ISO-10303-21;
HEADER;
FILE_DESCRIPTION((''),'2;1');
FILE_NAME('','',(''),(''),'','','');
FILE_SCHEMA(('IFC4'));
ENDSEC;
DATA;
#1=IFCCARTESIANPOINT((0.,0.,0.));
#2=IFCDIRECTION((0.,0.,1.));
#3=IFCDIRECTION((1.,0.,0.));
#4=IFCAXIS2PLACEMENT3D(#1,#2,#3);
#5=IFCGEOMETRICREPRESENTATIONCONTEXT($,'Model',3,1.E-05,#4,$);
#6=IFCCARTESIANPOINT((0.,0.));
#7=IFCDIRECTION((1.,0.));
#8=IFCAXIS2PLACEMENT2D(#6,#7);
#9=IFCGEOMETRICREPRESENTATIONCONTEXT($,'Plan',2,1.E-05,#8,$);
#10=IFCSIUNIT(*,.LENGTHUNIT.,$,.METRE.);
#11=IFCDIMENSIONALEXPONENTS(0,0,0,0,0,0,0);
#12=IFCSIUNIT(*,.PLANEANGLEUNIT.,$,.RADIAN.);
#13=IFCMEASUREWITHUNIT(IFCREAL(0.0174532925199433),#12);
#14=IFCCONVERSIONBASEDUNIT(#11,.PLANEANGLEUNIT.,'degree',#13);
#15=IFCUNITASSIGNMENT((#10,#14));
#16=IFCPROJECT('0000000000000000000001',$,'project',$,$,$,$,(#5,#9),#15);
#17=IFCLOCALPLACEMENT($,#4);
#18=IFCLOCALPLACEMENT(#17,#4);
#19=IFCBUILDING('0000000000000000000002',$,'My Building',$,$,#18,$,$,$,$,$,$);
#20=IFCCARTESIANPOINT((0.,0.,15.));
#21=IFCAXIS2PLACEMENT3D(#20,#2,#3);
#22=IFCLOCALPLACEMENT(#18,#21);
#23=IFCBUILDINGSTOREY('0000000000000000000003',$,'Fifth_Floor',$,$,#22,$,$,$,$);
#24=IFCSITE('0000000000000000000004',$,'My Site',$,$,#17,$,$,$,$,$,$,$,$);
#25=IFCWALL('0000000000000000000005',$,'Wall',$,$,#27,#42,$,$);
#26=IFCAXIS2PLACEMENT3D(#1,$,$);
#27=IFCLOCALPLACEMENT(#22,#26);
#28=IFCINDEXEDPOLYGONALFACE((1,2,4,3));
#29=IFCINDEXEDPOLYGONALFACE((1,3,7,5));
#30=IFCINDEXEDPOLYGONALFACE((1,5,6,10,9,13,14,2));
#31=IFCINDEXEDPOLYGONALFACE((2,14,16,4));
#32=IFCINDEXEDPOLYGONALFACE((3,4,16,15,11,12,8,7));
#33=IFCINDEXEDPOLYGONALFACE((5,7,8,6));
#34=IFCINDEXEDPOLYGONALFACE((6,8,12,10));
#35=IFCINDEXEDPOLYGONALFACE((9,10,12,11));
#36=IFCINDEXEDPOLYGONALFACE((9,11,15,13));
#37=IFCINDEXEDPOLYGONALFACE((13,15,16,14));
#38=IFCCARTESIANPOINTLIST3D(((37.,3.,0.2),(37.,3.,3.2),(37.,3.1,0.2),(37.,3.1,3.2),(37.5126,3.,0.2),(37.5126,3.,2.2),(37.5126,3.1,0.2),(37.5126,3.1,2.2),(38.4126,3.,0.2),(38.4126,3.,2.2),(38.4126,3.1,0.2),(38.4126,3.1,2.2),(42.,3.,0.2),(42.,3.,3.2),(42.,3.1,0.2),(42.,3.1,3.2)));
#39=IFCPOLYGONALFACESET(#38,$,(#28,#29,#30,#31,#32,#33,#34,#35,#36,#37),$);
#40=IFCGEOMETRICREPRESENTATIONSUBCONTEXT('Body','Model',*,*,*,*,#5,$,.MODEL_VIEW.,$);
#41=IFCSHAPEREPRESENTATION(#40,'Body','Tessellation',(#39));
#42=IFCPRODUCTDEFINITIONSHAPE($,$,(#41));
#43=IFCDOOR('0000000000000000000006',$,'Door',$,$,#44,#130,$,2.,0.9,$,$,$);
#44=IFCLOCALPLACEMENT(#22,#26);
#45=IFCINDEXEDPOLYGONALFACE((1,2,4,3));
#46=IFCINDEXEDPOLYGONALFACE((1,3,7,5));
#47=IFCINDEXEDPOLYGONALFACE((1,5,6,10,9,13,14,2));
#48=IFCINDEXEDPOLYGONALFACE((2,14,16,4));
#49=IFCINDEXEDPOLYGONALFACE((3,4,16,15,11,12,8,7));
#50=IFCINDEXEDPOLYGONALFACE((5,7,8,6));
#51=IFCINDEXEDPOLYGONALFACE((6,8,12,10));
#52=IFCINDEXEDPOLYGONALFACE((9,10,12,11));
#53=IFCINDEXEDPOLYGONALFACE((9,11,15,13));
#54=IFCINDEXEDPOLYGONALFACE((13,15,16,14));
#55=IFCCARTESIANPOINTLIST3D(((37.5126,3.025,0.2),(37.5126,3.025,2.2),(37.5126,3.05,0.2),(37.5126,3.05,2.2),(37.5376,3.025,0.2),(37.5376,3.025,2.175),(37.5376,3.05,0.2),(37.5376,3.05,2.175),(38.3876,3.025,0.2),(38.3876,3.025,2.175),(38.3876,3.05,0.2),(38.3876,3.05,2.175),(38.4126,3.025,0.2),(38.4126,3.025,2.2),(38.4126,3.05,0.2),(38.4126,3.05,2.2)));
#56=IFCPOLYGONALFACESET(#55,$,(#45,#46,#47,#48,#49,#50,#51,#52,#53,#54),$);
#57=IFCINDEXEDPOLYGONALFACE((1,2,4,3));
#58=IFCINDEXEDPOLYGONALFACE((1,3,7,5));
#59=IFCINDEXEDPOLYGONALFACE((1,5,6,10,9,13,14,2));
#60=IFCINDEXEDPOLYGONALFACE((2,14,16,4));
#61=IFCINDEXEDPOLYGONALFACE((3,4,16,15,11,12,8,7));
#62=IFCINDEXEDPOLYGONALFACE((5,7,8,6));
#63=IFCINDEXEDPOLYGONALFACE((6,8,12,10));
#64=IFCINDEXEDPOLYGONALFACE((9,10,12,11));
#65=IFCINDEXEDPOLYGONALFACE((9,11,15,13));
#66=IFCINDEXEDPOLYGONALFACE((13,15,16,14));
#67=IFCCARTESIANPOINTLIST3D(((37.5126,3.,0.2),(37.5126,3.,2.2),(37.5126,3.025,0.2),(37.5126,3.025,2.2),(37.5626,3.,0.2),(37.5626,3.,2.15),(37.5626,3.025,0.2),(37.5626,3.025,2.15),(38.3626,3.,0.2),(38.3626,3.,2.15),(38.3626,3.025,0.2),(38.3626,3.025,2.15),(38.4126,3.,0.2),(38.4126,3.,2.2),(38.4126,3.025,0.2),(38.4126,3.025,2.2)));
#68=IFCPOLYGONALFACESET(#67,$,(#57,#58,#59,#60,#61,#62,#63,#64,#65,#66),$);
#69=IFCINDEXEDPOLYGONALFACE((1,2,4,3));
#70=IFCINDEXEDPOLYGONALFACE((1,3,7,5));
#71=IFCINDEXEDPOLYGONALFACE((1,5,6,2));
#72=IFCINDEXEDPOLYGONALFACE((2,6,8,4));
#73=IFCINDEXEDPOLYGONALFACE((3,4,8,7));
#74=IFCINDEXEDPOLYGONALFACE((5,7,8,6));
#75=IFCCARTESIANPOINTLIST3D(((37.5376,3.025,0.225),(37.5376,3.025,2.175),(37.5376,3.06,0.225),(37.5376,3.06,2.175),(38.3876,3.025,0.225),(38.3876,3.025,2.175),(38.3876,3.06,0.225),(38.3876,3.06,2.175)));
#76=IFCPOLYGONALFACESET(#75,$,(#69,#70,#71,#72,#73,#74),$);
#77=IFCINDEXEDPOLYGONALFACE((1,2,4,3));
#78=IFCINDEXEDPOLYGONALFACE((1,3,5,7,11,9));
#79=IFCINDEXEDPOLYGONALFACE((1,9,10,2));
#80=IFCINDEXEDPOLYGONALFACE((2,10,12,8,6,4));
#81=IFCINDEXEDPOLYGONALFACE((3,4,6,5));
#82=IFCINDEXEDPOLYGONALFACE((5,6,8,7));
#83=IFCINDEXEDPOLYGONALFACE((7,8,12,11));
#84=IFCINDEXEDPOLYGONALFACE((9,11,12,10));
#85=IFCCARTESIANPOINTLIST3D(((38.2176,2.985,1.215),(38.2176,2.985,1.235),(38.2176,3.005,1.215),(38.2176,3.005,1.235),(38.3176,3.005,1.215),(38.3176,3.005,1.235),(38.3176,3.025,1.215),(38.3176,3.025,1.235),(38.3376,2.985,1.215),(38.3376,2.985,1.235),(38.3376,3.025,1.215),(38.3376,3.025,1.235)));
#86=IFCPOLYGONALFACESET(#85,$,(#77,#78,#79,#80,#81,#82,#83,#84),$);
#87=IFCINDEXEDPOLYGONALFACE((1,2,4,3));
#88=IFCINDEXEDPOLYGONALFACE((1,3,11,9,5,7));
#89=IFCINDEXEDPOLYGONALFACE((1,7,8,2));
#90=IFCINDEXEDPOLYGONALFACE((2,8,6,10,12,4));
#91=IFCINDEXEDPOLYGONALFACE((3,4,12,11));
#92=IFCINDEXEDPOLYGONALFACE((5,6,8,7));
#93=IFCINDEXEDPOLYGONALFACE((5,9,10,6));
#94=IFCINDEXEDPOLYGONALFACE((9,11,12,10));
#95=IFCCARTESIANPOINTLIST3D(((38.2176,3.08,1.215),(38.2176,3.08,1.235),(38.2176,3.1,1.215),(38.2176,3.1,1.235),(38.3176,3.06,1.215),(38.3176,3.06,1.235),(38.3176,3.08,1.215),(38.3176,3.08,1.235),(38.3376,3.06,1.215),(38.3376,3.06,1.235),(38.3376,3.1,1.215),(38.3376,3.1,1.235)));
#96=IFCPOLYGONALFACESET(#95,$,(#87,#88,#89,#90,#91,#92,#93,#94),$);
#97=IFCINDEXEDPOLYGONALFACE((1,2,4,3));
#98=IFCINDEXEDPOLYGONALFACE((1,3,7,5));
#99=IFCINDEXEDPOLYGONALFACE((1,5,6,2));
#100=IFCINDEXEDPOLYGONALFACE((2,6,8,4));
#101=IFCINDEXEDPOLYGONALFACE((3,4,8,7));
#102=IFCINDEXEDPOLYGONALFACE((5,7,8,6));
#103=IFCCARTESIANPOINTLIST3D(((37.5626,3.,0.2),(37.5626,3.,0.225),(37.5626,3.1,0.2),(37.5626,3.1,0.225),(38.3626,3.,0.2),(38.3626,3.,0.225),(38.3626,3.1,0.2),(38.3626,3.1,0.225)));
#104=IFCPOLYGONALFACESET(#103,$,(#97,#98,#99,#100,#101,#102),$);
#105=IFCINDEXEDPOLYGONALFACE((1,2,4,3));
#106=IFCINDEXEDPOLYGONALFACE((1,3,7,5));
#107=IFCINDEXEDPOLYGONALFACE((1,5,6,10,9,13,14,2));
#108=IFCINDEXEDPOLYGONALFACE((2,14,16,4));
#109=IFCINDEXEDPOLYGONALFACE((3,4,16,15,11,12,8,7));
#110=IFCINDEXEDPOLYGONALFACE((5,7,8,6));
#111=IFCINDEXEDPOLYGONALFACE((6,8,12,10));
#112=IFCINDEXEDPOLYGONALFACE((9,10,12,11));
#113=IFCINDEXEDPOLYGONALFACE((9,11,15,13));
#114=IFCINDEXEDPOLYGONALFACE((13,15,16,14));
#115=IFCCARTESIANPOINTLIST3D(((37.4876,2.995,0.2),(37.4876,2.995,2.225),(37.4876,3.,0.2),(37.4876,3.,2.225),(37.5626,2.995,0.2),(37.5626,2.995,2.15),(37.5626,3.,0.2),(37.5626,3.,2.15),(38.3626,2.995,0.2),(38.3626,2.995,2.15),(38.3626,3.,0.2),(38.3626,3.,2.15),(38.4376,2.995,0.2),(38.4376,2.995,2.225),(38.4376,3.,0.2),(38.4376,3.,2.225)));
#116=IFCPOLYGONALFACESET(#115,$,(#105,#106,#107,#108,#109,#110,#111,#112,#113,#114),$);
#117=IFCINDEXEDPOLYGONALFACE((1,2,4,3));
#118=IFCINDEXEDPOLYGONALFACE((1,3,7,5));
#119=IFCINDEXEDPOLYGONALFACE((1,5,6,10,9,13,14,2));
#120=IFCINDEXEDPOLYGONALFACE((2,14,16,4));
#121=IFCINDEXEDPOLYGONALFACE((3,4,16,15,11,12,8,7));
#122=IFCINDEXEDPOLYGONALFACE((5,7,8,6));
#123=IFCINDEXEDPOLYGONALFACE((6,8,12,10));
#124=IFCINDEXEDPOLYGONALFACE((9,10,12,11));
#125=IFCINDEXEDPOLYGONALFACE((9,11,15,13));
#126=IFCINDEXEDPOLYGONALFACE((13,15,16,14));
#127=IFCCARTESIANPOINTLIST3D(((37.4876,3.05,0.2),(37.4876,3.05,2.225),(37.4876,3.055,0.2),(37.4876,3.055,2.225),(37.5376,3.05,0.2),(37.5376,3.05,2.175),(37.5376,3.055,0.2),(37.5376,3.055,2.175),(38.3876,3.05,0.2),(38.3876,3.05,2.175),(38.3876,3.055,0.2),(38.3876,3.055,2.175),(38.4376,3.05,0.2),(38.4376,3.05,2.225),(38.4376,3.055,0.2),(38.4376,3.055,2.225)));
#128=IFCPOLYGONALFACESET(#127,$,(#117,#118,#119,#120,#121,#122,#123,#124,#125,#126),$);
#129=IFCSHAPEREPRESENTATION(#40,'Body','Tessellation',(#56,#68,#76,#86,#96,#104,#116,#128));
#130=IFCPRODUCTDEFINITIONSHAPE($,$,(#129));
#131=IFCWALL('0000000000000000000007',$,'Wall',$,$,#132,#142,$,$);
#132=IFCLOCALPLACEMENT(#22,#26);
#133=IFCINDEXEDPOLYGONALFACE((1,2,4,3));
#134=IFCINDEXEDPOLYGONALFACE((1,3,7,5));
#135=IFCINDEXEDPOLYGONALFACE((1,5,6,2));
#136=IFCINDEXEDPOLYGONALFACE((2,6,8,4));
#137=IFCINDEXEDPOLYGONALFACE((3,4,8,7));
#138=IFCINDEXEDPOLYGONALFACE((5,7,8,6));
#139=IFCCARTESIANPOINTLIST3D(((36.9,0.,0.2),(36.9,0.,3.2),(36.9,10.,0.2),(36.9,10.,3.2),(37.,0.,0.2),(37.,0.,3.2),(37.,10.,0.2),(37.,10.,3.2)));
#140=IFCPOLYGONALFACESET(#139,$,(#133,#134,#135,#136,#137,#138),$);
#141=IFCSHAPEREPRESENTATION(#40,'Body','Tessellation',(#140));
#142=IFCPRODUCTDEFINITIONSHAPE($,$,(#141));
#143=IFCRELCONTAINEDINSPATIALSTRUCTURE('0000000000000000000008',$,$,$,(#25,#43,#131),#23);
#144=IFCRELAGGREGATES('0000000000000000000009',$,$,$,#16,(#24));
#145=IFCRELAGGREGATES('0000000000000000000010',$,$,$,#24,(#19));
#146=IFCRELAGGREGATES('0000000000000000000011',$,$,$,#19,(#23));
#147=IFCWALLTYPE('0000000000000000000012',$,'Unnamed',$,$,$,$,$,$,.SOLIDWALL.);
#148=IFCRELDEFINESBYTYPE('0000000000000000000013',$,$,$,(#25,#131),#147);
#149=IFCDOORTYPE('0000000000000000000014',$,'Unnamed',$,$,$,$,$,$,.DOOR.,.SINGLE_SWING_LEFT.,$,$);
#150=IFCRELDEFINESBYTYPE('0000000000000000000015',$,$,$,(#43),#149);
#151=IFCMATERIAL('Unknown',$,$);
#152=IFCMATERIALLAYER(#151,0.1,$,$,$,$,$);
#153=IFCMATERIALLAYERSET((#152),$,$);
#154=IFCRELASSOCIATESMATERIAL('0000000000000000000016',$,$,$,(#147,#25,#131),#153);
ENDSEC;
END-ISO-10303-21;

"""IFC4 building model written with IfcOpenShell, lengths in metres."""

from ifc_helpers import new_model, entity, si_unit, converted_unit, frame, origin_with_axes, origin_2d_with_axis, place, context, subcontext, project, spatial, line, indexed_curve, outline, extrude, shape, source, transform, mapped, material, layer, layer_set, layer_usage, type_object, type_shapes, element, fill, save


model = new_model("IFC4")

# Units and contexts
model_context = context("Model", 3, precision=1e-05, world=origin_with_axes())
plan_context = context("Plan", 2, precision=1e-05, world=origin_2d_with_axis())
body_context_1 = subcontext(model_context, "Body", "Model", "MODEL_VIEW")
body_context_2 = subcontext(plan_context, "Body", "Plan", "PLAN_VIEW")
ifc_project = project(units=[si_unit("LENGTHUNIT", "METRE"), converted_unit("PLANEANGLEUNIT", "degree", entity("IfcReal", 0.0174532925199433), si_unit("PLANEANGLEUNIT", "RADIAN"), dimensions=[0, 0, 0, 0, 0, 0, 0])], contexts=[model_context, plan_context])

# Site, building, storey
site_placement = place(None, origin_with_axes())
site = spatial("IfcSite", under=ifc_project, at=site_placement, Name="My Site")
building_placement = place(site_placement, origin_with_axes())
building = spatial("IfcBuilding", under=site, at=building_placement, Name="My Building")
storey_placement = place(building_placement, frame((0.0, 0.0, 15.0), z_axis=(0.0, 0.0, 1.0), x_axis=(1.0, 0.0, 0.0)))
storey = spatial("IfcBuildingStorey", under=building, at=storey_placement, Name="Fifth_Floor")

# Wall, opening, door
ifc_material = material(Name="Unknown")
ifc_layer = layer(ifc_material, 0.1)
ifc_layer_set = layer_set([ifc_layer])
ifc_layer_usage_1 = layer_usage(ifc_layer_set, "AXIS2", "POSITIVE", 0.0)
wall_type = type_object("IfcWallType", Name="Unnamed", PredefinedType="SOLIDWALL", material=ifc_layer_set)
wall_1_placement = place(storey_placement, frame((37.0, 3.0, 0.2), z_axis=(0.0, 0.0, 1.0), x_axis=(1.0, 0.0, 0.0)))
wall_1 = element("IfcWall", 1, at=wall_1_placement, inside=storey, type_object=wall_type, material=ifc_layer_usage_1, Name="Wall", context=body_context_1, shape_type="SweptSolid", body=[
    extrude(outline(indexed_curve([(0.0, 0.0), (0.0, 0.1), (5.0, 0.1), (5.0, 0.0)], segments=[line(1, 2, 3, 4, 1)])), origin_with_axes(), (0.0, 0.0, 1.0), 3.0),
])
shared_shape_1 = source(origin_with_axes(), body_context_1, "Body", "SweptSolid", [
    extrude(outline(indexed_curve([(0.0, 0.0), (0.9, 0.0), (0.9, 2.0), (0.0, 2.0)], segments=[line(1, 2, 3, 4, 1)])), frame((0.0, -0.6, 0.0), z_axis=(0.0, -1.0, 0.0), x_axis=(1.0, 0.0, 0.0)), (0.0, 0.0, -1.0), 1.2),
])
opening_1_placement = place(wall_1_placement, frame((0.5126, 0.0, 0.0), z_axis=(0.0, 0.0, 1.0), x_axis=(1.0, 0.0, 0.0)))
opening_1 = element("IfcOpeningElement", 2, at=opening_1_placement, cuts=wall_1, PredefinedType="OPENING", context=body_context_1, shape_type="MappedRepresentation", body=[
    mapped(shared_shape_1, transform((0.0, 0.0, 0.0), x_axis=(1.0, 0.0, 0.0), y_axis=(0.0, 1.0, 0.0), z_axis=(0.0, 0.0, 1.0), scale=1.0)),
])
door_type = type_object("IfcDoorType", Name="Unnamed", OperationType="SINGLE_SWING_LEFT", PredefinedType="DOOR")
shared_shape_2 = source(origin_with_axes(), body_context_1, "Body", "SweptSolid", [
    extrude(outline(indexed_curve([(0.0, 0.0), (0.0, 2.0), (0.9, 2.0), (0.9, 0.0), (0.875, 0.0), (0.875, 1.975), (0.025, 1.975), (0.025, 0.0)], segments=[line(1, 2, 3, 4, 5, 6, 7, 8, 1)])), frame((0.0, 0.025, 0.0), z_axis=(0.0, -1.0, 0.0), x_axis=(1.0, 0.0, 0.0)), (0.0, 0.0, -1.0), 0.025),
    extrude(outline(indexed_curve([(0.0, 0.0), (0.0, 2.0), (0.9, 2.0), (0.9, 0.0), (0.85, 0.0), (0.85, 1.95), (0.05, 1.95), (0.05, 0.0)], segments=[line(1, 2, 3, 4, 5, 6, 7, 8, 1)])), frame((0.0, 0.0, 0.0), z_axis=(0.0, -1.0, 0.0), x_axis=(1.0, 0.0, 0.0)), (0.0, 0.0, -1.0), 0.025),
    extrude(outline(indexed_curve([(0.0, 0.0), (0.85, 0.0), (0.85, 0.035), (0.0, 0.035)], segments=[line(1, 2, 3, 4, 1)])), frame((0.025, 0.025, 0.025), z_axis=(0.0, 0.0, 1.0), x_axis=(1.0, 0.0, 0.0)), (0.0, 0.0, 1.0), 1.95),
    extrude(outline(indexed_curve([(0.0, 0.0), (0.0, -0.04), (-0.12, -0.04), (-0.12, -0.02), (-0.02, -0.02), (-0.02, 0.0)], segments=[line(1, 2, 3, 4, 5, 6, 1)])), frame((0.825, 0.025, 1.015), z_axis=(0.0, 0.0, 1.0), x_axis=(1.0, 0.0, 0.0)), (0.0, 0.0, 1.0), 0.02),
    extrude(outline(indexed_curve([(0.0, 0.0), (0.0, 0.04), (-0.12, 0.04), (-0.12, 0.02), (-0.02, 0.02), (-0.02, 0.0)], segments=[line(1, 2, 3, 4, 5, 6, 1)])), frame((0.825, 0.06, 1.015), z_axis=(0.0, 0.0, 1.0), x_axis=(1.0, 0.0, 0.0)), (0.0, 0.0, 1.0), 0.02),
    extrude(outline(indexed_curve([(0.0, 0.0), (0.8, 0.0), (0.8, 0.1), (0.0, 0.1)], segments=[line(1, 2, 3, 4, 1)])), frame((0.05, 0.0, 0.0), z_axis=(0.0, 0.0, 1.0), x_axis=(1.0, 0.0, 0.0)), (0.0, 0.0, 1.0), 0.025),
    extrude(outline(indexed_curve([(0.0, 0.0), (0.0, 2.025), (0.95, 2.025), (0.95, 0.0), (0.875, 0.0), (0.875, 1.95), (0.075, 1.95), (0.075, 0.0)], segments=[line(1, 2, 3, 4, 5, 6, 7, 8, 1)])), frame((-0.025, -0.005, 0.0), z_axis=(0.0, -1.0, 0.0), x_axis=(1.0, 0.0, 0.0)), (0.0, 0.0, -1.0), 0.005),
    extrude(outline(indexed_curve([(0.0, 0.0), (0.0, 2.025), (0.95, 2.025), (0.95, 0.0), (0.9, 0.0), (0.9, 1.975), (0.05, 1.975), (0.05, 0.0)], segments=[line(1, 2, 3, 4, 5, 6, 7, 8, 1)])), frame((-0.025, 0.05, 0.0), z_axis=(0.0, -1.0, 0.0), x_axis=(1.0, 0.0, 0.0)), (0.0, 0.0, -1.0), 0.005),
])
shared_shape_3 = source(origin_with_axes(), body_context_2, "Body", "Curve2D", [
    entity("IfcIndexedPolyCurve", entity("IfcCartesianPointList2D", [[0.0, 0.0], [0.0, 0.05], [0.025, 0.05], [0.025, 0.025], [0.05, 0.025], [0.05, 0.0]]), [entity("IfcLineIndex", [1, 2, 3, 4, 5, 6, 1])]),
    entity("IfcIndexedPolyCurve", entity("IfcCartesianPointList2D", [[0.9, 0.0], [0.9, 0.05], [0.875, 0.05], [0.875, 0.025], [0.85, 0.025], [0.85, 0.0]]), [entity("IfcLineIndex", [1, 2, 3, 4, 5, 6, 1])]),
    entity("IfcTrimmedCurve", entity("IfcEllipse", entity("IfcAxis2Placement2D", entity("IfcCartesianPoint", [0.06, 0.05]), entity("IfcDirection", [1.0, 0.0])), 0.815, 0.85), [entity("IfcCartesianPoint", [0.875, 0.05])], [entity("IfcCartesianPoint", [0.06, 0.9])], True, "CARTESIAN"),
    entity("IfcIndexedPolyCurve", entity("IfcCartesianPointList2D", [[0.025, 0.05], [0.06, 0.05], [0.06, 0.9], [0.025, 0.9]]), [entity("IfcLineIndex", [1, 2, 3, 4, 1])]),
])
type_shapes(door_type, [shared_shape_2, shared_shape_3])
door_1_placement = place(opening_1_placement, origin_with_axes())
door_1 = element("IfcDoor", 3, at=door_1_placement, inside=storey, type_object=door_type, Name="Door", OverallHeight=2.0, OverallWidth=0.9, shapes=[
    shape(body_context_1, "Body", "MappedRepresentation", [mapped(shared_shape_2, transform((0.0, 0.0, 0.0), x_axis=(1.0, 0.0, 0.0), y_axis=(0.0, 1.0, 0.0), z_axis=(0.0, 0.0, 1.0), scale=1.0))]),
    shape(body_context_2, "Body", "MappedRepresentation", [mapped(shared_shape_3, transform((0.0, 0.0, 0.0), x_axis=(1.0, 0.0, 0.0), y_axis=(0.0, 1.0, 0.0), z_axis=(0.0, 0.0, 1.0), scale=1.0))]),
])
fill(opening_1, door_1)

# Wall
ifc_layer_usage_2 = layer_usage(ifc_layer_set, "AXIS2", "POSITIVE", 0.0)
wall_2_placement = place(storey_placement, frame((36.9, 10.0, 0.2), z_axis=(0.0, 0.0, 1.0), x_axis=(0.0, -1.0, 0.0)))
element("IfcWall", 4, at=wall_2_placement, inside=storey, type_object=wall_type, material=ifc_layer_usage_2, Name="Wall", context=body_context_1, shape_type="SweptSolid", body=[
    extrude(outline(indexed_curve([(0.0, 0.0), (0.0, 0.1), (10.0, 0.1), (10.0, 0.0)], segments=[line(1, 2, 3, 4, 1)])), origin_with_axes(), (0.0, 0.0, 1.0), 3.0),
])

save(model, "model.ifc")
